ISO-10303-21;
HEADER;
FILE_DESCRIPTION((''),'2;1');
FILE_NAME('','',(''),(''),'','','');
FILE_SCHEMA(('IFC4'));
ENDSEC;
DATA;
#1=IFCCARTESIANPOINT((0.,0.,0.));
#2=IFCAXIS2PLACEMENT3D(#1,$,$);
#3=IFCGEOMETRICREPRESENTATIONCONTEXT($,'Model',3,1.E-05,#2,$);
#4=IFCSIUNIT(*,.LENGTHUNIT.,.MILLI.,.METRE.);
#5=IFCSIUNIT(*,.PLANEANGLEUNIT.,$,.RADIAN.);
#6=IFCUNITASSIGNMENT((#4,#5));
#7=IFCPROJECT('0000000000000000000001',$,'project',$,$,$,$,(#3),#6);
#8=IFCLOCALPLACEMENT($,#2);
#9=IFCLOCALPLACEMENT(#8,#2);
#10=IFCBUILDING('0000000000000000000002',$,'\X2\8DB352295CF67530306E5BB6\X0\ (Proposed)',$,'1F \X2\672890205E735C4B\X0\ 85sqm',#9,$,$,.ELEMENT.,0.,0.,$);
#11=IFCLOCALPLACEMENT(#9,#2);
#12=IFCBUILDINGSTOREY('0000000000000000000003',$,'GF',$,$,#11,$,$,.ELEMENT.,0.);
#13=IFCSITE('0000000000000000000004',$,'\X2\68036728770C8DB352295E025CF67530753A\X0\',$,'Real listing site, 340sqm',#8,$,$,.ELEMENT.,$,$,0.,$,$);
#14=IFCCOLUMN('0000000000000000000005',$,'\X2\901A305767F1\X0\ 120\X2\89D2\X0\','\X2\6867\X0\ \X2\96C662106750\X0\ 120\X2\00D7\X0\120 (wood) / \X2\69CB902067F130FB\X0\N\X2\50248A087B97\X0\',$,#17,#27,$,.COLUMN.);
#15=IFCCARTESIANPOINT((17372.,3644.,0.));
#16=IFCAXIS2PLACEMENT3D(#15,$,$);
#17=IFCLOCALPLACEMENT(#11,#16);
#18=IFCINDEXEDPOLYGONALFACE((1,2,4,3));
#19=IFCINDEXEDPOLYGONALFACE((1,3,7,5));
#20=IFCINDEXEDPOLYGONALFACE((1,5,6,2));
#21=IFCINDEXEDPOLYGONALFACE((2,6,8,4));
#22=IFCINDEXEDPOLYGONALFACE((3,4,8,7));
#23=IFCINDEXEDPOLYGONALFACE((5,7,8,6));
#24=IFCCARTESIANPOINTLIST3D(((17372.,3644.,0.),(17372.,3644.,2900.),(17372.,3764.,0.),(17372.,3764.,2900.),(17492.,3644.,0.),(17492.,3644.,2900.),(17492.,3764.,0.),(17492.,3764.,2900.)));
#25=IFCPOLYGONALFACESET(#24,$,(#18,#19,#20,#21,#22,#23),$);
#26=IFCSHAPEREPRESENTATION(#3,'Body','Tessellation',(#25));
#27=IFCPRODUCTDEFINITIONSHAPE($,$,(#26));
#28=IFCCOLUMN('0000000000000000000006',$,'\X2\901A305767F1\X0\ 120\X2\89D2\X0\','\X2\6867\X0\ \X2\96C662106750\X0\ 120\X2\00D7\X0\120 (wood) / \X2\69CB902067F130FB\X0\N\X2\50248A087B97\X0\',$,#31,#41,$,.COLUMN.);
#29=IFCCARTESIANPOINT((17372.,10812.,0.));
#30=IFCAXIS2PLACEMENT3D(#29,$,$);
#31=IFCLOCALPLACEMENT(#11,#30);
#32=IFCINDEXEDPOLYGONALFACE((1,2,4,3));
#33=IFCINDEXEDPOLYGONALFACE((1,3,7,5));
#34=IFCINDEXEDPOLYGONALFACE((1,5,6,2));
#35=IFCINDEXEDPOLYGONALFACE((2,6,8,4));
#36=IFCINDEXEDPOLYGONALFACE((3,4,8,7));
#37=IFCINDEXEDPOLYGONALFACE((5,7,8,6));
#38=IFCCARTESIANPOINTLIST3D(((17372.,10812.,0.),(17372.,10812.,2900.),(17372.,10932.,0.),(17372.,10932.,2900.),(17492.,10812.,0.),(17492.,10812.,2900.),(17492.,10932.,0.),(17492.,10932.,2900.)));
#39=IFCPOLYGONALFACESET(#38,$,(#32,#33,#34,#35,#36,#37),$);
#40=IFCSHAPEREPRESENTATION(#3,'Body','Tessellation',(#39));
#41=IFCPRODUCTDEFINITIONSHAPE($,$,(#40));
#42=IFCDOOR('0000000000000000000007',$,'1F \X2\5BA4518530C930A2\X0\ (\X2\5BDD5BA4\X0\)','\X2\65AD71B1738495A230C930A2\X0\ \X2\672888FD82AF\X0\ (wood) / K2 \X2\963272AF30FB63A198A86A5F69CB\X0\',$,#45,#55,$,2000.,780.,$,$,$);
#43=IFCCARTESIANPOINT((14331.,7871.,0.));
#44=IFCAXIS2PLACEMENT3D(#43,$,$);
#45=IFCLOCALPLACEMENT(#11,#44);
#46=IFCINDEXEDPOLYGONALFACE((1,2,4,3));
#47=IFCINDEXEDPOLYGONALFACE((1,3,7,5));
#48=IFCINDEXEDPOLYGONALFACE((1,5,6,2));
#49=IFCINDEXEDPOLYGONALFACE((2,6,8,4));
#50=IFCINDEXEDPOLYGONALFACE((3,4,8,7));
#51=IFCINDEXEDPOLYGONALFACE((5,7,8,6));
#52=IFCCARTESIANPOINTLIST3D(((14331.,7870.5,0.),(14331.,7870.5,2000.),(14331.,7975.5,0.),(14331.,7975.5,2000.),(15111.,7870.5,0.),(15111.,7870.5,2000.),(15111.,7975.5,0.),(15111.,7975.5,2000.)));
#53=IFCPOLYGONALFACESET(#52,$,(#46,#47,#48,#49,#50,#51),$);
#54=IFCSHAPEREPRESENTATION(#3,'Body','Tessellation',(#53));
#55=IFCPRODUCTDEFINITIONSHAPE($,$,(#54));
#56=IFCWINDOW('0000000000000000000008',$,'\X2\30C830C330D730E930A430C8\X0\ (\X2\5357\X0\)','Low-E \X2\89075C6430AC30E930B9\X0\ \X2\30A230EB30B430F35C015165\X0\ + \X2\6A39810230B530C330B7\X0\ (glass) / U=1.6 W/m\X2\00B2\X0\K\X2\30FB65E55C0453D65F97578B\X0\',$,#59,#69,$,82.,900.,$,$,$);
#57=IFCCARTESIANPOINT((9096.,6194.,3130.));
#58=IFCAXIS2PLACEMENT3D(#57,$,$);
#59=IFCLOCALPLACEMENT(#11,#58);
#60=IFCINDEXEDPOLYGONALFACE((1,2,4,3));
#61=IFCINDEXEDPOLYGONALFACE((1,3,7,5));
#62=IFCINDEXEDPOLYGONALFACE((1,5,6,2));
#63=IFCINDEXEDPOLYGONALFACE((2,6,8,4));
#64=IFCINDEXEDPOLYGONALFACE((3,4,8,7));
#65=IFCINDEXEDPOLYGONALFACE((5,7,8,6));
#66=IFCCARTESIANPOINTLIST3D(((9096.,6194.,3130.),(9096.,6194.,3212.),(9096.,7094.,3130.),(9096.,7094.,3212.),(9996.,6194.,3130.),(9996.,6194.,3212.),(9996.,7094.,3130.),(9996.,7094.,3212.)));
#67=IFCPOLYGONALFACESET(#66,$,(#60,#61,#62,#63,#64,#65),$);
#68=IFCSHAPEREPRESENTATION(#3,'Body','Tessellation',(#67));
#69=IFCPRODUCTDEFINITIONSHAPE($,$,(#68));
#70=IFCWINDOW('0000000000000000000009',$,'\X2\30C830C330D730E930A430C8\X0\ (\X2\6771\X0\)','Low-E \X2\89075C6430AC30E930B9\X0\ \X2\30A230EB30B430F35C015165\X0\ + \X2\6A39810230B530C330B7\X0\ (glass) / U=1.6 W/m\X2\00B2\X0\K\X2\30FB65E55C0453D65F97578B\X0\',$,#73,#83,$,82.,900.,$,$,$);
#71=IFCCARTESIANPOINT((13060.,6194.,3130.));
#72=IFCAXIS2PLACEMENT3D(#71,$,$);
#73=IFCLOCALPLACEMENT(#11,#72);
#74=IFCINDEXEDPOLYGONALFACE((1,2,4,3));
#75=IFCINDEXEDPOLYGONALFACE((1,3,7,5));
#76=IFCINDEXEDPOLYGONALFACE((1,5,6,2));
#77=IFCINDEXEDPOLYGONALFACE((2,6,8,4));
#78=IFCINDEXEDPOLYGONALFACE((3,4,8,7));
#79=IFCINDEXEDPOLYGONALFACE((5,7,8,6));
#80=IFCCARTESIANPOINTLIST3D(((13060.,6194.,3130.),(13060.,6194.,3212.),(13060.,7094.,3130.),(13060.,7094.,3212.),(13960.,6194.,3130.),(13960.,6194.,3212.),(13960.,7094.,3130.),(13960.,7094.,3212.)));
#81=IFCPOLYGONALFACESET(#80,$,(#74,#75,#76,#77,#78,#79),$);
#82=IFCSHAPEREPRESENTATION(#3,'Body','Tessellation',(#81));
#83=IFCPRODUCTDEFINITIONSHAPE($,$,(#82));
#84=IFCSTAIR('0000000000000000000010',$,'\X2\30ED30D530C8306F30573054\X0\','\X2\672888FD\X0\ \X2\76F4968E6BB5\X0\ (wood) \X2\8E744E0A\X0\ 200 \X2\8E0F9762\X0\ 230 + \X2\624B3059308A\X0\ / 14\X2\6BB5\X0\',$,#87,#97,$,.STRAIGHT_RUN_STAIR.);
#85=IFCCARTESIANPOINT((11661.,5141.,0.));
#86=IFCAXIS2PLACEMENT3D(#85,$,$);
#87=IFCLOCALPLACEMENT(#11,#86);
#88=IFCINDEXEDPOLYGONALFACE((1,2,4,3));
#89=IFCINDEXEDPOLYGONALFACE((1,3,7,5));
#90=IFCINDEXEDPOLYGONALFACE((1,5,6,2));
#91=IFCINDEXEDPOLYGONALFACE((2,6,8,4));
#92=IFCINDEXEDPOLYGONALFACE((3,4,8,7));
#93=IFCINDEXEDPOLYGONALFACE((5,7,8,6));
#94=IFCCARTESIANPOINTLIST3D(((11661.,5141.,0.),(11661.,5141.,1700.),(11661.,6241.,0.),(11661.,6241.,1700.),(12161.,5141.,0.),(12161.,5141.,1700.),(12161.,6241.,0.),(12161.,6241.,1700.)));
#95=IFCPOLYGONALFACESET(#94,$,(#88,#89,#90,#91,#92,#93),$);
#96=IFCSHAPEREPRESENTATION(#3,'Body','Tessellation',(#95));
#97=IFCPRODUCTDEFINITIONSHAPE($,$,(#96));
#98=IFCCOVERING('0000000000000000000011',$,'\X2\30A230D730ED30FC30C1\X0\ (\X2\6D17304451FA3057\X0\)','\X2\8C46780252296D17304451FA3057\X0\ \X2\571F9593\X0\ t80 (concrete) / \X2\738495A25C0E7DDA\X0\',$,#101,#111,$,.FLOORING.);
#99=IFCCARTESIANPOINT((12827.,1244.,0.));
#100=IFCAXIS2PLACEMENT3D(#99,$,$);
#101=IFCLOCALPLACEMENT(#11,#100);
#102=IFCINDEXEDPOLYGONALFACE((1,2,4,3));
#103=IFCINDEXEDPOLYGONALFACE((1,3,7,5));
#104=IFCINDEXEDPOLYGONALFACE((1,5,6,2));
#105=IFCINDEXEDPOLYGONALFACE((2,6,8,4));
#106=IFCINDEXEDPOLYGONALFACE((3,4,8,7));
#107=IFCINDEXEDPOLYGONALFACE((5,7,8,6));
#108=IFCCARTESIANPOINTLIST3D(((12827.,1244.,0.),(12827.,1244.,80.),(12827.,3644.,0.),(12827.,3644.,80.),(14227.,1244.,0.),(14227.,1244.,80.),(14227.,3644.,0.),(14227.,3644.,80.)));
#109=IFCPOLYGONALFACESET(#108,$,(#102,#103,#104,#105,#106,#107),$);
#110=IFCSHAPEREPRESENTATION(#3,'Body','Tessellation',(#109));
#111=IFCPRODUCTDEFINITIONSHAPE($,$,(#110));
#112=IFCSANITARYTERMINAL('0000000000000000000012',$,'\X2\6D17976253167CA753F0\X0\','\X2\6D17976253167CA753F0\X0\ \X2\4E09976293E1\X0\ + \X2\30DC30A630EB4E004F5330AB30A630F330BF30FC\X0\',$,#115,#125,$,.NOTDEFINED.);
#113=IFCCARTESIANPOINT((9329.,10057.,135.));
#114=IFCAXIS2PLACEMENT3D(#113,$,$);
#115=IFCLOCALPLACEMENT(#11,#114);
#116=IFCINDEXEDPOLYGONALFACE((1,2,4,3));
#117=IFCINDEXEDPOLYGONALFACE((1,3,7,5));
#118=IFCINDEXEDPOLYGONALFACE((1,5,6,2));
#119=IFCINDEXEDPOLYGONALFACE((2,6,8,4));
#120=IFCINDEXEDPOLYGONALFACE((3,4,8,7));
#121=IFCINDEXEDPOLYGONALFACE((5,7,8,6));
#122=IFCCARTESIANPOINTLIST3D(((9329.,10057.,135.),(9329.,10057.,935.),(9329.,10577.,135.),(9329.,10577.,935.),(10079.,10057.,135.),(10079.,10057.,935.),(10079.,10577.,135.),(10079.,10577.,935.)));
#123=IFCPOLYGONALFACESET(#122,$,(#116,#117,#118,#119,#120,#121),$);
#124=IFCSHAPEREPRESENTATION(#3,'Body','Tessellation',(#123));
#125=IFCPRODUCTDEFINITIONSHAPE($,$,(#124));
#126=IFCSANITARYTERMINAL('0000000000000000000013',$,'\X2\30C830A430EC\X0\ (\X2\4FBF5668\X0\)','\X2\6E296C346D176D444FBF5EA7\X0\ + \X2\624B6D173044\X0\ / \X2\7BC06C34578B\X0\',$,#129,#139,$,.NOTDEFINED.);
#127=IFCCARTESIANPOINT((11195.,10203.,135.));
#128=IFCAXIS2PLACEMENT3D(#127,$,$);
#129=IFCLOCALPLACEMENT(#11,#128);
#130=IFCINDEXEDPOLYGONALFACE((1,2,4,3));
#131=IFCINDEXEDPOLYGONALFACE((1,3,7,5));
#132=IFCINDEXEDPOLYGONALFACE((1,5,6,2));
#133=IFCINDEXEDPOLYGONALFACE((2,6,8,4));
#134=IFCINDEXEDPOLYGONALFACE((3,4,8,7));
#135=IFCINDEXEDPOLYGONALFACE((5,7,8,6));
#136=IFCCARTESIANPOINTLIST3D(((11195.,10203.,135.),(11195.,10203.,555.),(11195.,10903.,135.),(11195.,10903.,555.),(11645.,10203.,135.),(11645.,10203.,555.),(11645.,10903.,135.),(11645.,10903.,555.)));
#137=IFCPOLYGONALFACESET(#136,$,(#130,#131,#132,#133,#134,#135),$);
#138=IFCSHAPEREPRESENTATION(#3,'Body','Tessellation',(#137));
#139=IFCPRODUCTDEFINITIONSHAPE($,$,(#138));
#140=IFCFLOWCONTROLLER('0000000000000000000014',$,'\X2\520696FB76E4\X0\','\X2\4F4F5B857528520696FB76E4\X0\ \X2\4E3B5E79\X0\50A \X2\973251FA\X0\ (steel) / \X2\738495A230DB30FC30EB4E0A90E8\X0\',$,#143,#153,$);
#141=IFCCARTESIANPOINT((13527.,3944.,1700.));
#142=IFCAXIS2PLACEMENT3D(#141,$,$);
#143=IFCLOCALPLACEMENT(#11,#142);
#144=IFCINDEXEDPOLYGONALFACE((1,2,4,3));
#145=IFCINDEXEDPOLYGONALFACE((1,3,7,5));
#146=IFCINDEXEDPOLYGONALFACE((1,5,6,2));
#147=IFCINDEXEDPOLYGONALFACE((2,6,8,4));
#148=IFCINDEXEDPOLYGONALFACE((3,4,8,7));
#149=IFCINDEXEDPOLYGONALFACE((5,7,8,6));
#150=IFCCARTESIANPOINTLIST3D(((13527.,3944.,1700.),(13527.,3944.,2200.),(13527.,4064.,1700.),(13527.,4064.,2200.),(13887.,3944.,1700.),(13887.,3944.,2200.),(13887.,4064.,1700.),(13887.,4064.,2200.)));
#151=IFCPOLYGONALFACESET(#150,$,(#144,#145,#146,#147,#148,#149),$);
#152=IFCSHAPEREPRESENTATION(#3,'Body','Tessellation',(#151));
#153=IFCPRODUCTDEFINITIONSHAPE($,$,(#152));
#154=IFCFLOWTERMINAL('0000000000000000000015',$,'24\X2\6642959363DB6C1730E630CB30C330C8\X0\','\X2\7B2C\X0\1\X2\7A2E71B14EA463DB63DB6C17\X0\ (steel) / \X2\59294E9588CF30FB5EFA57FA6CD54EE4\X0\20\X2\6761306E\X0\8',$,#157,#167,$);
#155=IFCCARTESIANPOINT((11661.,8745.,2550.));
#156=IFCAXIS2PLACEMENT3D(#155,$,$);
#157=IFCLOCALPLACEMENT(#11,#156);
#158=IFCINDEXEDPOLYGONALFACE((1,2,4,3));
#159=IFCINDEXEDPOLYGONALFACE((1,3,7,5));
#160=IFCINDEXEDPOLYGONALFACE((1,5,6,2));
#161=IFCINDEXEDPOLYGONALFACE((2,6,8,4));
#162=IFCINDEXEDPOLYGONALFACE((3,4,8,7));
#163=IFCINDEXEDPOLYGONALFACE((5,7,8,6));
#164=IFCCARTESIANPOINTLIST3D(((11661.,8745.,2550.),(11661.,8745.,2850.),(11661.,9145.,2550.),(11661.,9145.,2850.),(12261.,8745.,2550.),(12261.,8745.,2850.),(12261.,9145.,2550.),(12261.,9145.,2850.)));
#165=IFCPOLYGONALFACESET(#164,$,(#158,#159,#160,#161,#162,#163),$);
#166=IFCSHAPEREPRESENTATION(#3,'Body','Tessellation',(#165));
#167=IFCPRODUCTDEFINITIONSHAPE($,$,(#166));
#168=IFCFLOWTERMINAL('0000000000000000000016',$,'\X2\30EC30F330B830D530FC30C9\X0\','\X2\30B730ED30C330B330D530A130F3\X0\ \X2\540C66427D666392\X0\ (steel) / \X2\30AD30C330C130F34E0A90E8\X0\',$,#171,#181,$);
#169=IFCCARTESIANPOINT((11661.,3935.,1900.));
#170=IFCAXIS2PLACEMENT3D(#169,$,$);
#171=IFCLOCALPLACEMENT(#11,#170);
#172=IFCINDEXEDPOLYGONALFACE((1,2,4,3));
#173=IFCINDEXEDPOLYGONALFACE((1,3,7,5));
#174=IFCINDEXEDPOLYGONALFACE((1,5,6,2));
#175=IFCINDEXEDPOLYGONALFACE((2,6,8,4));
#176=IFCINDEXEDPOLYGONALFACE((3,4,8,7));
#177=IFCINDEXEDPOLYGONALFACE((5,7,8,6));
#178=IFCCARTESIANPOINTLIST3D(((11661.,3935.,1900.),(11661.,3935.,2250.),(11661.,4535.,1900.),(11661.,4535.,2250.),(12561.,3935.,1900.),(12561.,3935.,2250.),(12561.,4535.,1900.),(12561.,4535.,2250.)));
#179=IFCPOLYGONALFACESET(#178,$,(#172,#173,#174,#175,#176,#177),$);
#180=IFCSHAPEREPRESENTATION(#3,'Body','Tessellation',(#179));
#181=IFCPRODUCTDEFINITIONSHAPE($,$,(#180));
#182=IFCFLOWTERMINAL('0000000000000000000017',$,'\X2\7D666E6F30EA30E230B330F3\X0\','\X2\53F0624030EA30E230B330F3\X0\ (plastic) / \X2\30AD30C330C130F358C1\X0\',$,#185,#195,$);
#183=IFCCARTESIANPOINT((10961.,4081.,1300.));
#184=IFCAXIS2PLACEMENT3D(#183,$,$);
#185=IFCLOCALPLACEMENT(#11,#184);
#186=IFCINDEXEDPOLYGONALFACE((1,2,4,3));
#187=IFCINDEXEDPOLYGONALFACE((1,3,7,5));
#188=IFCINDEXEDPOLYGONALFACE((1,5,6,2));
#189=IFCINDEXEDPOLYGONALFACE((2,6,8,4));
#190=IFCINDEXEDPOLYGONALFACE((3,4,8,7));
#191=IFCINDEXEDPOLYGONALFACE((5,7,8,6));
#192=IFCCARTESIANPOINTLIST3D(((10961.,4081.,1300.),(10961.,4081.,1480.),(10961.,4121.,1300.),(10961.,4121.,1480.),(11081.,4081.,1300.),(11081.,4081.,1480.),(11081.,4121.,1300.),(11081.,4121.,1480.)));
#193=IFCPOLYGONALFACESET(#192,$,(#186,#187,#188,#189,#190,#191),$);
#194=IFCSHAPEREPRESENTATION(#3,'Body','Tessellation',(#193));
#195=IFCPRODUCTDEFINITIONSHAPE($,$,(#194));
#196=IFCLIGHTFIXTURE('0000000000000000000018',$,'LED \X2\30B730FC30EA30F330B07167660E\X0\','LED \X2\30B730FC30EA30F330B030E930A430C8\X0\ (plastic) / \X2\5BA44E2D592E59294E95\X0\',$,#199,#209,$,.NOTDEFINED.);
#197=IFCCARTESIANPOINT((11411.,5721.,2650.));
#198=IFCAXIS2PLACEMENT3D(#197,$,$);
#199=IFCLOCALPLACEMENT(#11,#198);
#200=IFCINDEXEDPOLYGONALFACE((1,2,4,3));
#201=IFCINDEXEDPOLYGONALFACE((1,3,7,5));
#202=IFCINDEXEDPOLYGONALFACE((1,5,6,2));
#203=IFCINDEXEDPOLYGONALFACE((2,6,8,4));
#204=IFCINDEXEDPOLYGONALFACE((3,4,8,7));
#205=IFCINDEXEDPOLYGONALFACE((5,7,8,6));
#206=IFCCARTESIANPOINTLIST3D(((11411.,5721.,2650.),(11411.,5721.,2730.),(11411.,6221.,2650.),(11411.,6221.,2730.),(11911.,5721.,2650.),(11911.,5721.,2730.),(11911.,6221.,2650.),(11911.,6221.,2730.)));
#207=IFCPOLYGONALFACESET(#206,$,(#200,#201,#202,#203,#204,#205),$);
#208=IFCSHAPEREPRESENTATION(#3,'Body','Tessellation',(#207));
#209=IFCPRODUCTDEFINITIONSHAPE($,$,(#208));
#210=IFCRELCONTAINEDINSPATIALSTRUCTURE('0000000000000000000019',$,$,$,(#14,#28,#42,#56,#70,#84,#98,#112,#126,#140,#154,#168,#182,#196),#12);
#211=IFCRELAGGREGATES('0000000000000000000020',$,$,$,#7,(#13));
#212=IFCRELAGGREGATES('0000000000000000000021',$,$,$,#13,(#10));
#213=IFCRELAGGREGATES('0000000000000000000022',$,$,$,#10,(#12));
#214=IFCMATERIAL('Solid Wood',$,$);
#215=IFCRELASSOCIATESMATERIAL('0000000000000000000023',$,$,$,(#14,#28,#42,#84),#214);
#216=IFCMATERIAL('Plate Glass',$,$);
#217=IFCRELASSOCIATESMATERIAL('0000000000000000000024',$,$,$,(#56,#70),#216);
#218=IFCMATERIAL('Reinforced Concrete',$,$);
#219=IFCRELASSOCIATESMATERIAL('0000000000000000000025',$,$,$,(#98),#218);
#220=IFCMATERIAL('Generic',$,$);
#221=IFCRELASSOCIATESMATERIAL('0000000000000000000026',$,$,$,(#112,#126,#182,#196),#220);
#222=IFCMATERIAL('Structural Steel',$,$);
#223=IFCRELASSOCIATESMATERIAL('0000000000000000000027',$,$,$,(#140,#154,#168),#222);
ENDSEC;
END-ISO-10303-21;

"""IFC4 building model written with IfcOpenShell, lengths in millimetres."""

from ifc_helpers import new_model, si_unit, frame, frame_2d, origin, place, context, project, spatial, rectangle, extrude, material, element, save


model = new_model("IFC4")

# Units and contexts
model_context = context("Model", 3, precision=1e-05, world=origin())
ifc_project = project(units=[si_unit("LENGTHUNIT", "METRE", prefix="MILLI"), si_unit("PLANEANGLEUNIT", "RADIAN")], contexts=[model_context])

# Site, building, storey
site_placement = place(None, origin())
site = spatial("IfcSite", under=ifc_project, at=site_placement, Name="栃木県足利市島田町", ObjectType="Real listing site, 340sqm", CompositionType="ELEMENT", RefElevation=0.0)
building_placement = place(site_placement, origin())
building = spatial("IfcBuilding", under=site, at=building_placement, Name="足利島田の家 (Proposed)", ObjectType="1F 木造平屋 85sqm", CompositionType="ELEMENT", ElevationOfRefHeight=0.0, ElevationOfTerrain=0.0)
storey_placement = place(building_placement, origin())
storey = spatial("IfcBuildingStorey", under=building, at=storey_placement, Name="GF", CompositionType="ELEMENT", Elevation=0.0)

# Columns
ifc_material_1 = material(Name="Solid Wood")
column_1_placement = place(storey_placement, frame((17372.0, 3644.0, 0.0)))
element("IfcColumn", 1, at=column_1_placement, inside=storey, material=ifc_material_1, Name="通し柱 120角", Description="桧 集成材 120×120 (wood) / 構造柱・N値計算", PredefinedType="COLUMN", context=model_context, shape_type="SweptSolid", body=[
    extrude(rectangle(XDim=120.0, YDim=120.0, at=frame_2d((60.0, 60.0))), frame((17372.0, 3644.0, 0.0)), (0.0, 0.0, 1.0), 2900.0),
])
column_2_placement = place(storey_placement, frame((17372.0, 10812.0, 0.0)))
element("IfcColumn", 2, at=column_2_placement, inside=storey, material=ifc_material_1, Name="通し柱 120角", Description="桧 集成材 120×120 (wood) / 構造柱・N値計算", PredefinedType="COLUMN", context=model_context, shape_type="SweptSolid", body=[
    extrude(rectangle(XDim=120.0, YDim=120.0, at=frame_2d((60.0, 60.0))), frame((17372.0, 10812.0, 0.0)), (0.0, 0.0, 1.0), 2900.0),
])

# Shared definitions
ifc_material_2 = material(Name="Plate Glass")

# Door
door_placement = place(storey_placement, frame((14331.0, 7871.0, 0.0)))
element("IfcDoor", 3, at=door_placement, inside=storey, material=ifc_material_1, Name="1F 室内ドア (寝室)", Description="断熱玄関ドア 木製芯 (wood) / K2 防犯・採風機構", OverallHeight=2000.0, OverallWidth=780.0, context=model_context, shape_type="SweptSolid", body=[
    extrude(rectangle(XDim=780.0, YDim=105.0, at=frame_2d((390.0, 52.0))), frame((14331.0, 7871.0, 0.0)), (0.0, 0.0, 1.0), 2000.0),
])

# Windows
window_1_placement = place(storey_placement, frame((9096.0, 6194.0, 3130.0)))
element("IfcWindow", 4, at=window_1_placement, inside=storey, material=ifc_material_2, Name="トップライト (南)", Description="Low-E 複層ガラス アルゴン封入 + 樹脂サッシ (glass) / U=1.6 W/m²K・日射取得型", OverallHeight=82.0, OverallWidth=900.0, context=model_context, shape_type="SweptSolid", body=[
    extrude(rectangle(XDim=900.0, YDim=900.0, at=frame_2d((450.0, 450.0))), frame((9096.0, 6194.0, 3130.0)), (0.0, 0.0, 1.0), 82.0),
])
window_2_placement = place(storey_placement, frame((13060.0, 6194.0, 3130.0)))
element("IfcWindow", 5, at=window_2_placement, inside=storey, material=ifc_material_2, Name="トップライト (東)", Description="Low-E 複層ガラス アルゴン封入 + 樹脂サッシ (glass) / U=1.6 W/m²K・日射取得型", OverallHeight=82.0, OverallWidth=900.0, context=model_context, shape_type="SweptSolid", body=[
    extrude(rectangle(XDim=900.0, YDim=900.0, at=frame_2d((450.0, 450.0))), frame((13060.0, 6194.0, 3130.0)), (0.0, 0.0, 1.0), 82.0),
])

# Stair
stair_placement = place(storey_placement, frame((11661.0, 5141.0, 0.0)))
element("IfcStair", 6, at=stair_placement, inside=storey, material=ifc_material_1, Name="ロフトはしご", Description="木製 直階段 (wood) 蹴上 200 踏面 230 + 手すり / 14段", PredefinedType="STRAIGHT_RUN_STAIR", context=model_context, shape_type="SweptSolid", body=[
    extrude(rectangle(XDim=500.0, YDim=1100.0, at=frame_2d((250.0, 550.0))), frame((11661.0, 5141.0, 0.0)), (0.0, 0.0, 1.0), 1700.0),
])

# Covering
ifc_material_3 = material(Name="Reinforced Concrete")
covering_placement = place(storey_placement, frame((12827.0, 1244.0, 0.0)))
element("IfcCovering", 7, at=covering_placement, inside=storey, material=ifc_material_3, Name="アプローチ (洗い出し)", Description="豆砂利洗い出し 土間 t80 (concrete) / 玄関導線", PredefinedType="FLOORING", context=model_context, shape_type="SweptSolid", body=[
    extrude(rectangle(XDim=1400.0, YDim=2400.0, at=frame_2d((700.0, 1200.0))), frame((12827.0, 1244.0, 0.0)), (0.0, 0.0, 1.0), 80.0),
])

# Sanitary terminals
ifc_material_4 = material(Name="Generic")
sanitary_terminal_1_placement = place(storey_placement, frame((9329.0, 10057.0, 135.0)))
element("IfcSanitaryTerminal", 8, at=sanitary_terminal_1_placement, inside=storey, material=ifc_material_4, Name="洗面化粧台", Description="洗面化粧台 三面鏡 + ボウル一体カウンター", PredefinedType="NOTDEFINED", context=model_context, shape_type="SweptSolid", body=[
    extrude(rectangle(XDim=750.0, YDim=520.0, at=frame_2d((375.0, 260.0))), frame((9329.0, 10057.0, 135.0)), (0.0, 0.0, 1.0), 800.0),
])
sanitary_terminal_2_placement = place(storey_placement, frame((11195.0, 10203.0, 135.0)))
element("IfcSanitaryTerminal", 9, at=sanitary_terminal_2_placement, inside=storey, material=ifc_material_4, Name="トイレ (便器)", Description="温水洗浄便座 + 手洗い / 節水型", PredefinedType="NOTDEFINED", context=model_context, shape_type="SweptSolid", body=[
    extrude(rectangle(XDim=450.0, YDim=700.0, at=frame_2d((225.0, 350.0))), frame((11195.0, 10203.0, 135.0)), (0.0, 0.0, 1.0), 420.0),
])

# Flow controller
ifc_material_5 = material(Name="Structural Steel")
flow_controller_placement = place(storey_placement, frame((13527.0, 3944.0, 1700.0)))
element("IfcFlowController", 10, at=flow_controller_placement, inside=storey, material=ifc_material_5, Name="分電盤", Description="住宅用分電盤 主幹50A 露出 (steel) / 玄関ホール上部", context=model_context, shape_type="SweptSolid", body=[
    extrude(rectangle(XDim=360.0, YDim=120.0, at=frame_2d((180.0, 60.0))), frame((13527.0, 3944.0, 1700.0)), (0.0, 0.0, 1.0), 500.0),
])

# Flow terminals
flow_terminal_1_placement = place(storey_placement, frame((11661.0, 8745.0, 2550.0)))
element("IfcFlowTerminal", 11, at=flow_terminal_1_placement, inside=storey, material=ifc_material_5, Name="24時間換気ユニット", Description="第1種熱交換換気 (steel) / 天井裏・建基法令20条の8", context=model_context, shape_type="SweptSolid", body=[
    extrude(rectangle(XDim=600.0, YDim=400.0, at=frame_2d((300.0, 200.0))), frame((11661.0, 8745.0, 2550.0)), (0.0, 0.0, 1.0), 300.0),
])
flow_terminal_2_placement = place(storey_placement, frame((11661.0, 3935.0, 1900.0)))
element("IfcFlowTerminal", 12, at=flow_terminal_2_placement, inside=storey, material=ifc_material_5, Name="レンジフード", Description="シロッコファン 同時給排 (steel) / キッチン上部", context=model_context, shape_type="SweptSolid", body=[
    extrude(rectangle(XDim=900.0, YDim=600.0, at=frame_2d((450.0, 300.0))), frame((11661.0, 3935.0, 1900.0)), (0.0, 0.0, 1.0), 350.0),
])
flow_terminal_3_placement = place(storey_placement, frame((10961.0, 4081.0, 1300.0)))
element("IfcFlowTerminal", 13, at=flow_terminal_3_placement, inside=storey, material=ifc_material_4, Name="給湯リモコン", Description="台所リモコン (plastic) / キッチン壁", context=model_context, shape_type="SweptSolid", body=[
    extrude(rectangle(XDim=120.0, YDim=40.0, at=frame_2d((60.0, 20.0))), frame((10961.0, 4081.0, 1300.0)), (0.0, 0.0, 1.0), 180.0),
])

# Light fixture
light_fixture_1_placement = place(storey_placement, frame((11411.0, 5721.0, 2650.0)))
element("IfcLightFixture", 14, at=light_fixture_1_placement, inside=storey, material=ifc_material_4, Name="LED シーリング照明", Description="LED シーリングライト (plastic) / 室中央天井", PredefinedType="NOTDEFINED", context=model_context, shape_type="SweptSolid", body=[
    extrude(rectangle(XDim=500.0, YDim=500.0, at=frame_2d((250.0, 250.0))), frame((11411.0, 5721.0, 2650.0)), (0.0, 0.0, 1.0), 80.0),
])

save(model, "model.ifc")
